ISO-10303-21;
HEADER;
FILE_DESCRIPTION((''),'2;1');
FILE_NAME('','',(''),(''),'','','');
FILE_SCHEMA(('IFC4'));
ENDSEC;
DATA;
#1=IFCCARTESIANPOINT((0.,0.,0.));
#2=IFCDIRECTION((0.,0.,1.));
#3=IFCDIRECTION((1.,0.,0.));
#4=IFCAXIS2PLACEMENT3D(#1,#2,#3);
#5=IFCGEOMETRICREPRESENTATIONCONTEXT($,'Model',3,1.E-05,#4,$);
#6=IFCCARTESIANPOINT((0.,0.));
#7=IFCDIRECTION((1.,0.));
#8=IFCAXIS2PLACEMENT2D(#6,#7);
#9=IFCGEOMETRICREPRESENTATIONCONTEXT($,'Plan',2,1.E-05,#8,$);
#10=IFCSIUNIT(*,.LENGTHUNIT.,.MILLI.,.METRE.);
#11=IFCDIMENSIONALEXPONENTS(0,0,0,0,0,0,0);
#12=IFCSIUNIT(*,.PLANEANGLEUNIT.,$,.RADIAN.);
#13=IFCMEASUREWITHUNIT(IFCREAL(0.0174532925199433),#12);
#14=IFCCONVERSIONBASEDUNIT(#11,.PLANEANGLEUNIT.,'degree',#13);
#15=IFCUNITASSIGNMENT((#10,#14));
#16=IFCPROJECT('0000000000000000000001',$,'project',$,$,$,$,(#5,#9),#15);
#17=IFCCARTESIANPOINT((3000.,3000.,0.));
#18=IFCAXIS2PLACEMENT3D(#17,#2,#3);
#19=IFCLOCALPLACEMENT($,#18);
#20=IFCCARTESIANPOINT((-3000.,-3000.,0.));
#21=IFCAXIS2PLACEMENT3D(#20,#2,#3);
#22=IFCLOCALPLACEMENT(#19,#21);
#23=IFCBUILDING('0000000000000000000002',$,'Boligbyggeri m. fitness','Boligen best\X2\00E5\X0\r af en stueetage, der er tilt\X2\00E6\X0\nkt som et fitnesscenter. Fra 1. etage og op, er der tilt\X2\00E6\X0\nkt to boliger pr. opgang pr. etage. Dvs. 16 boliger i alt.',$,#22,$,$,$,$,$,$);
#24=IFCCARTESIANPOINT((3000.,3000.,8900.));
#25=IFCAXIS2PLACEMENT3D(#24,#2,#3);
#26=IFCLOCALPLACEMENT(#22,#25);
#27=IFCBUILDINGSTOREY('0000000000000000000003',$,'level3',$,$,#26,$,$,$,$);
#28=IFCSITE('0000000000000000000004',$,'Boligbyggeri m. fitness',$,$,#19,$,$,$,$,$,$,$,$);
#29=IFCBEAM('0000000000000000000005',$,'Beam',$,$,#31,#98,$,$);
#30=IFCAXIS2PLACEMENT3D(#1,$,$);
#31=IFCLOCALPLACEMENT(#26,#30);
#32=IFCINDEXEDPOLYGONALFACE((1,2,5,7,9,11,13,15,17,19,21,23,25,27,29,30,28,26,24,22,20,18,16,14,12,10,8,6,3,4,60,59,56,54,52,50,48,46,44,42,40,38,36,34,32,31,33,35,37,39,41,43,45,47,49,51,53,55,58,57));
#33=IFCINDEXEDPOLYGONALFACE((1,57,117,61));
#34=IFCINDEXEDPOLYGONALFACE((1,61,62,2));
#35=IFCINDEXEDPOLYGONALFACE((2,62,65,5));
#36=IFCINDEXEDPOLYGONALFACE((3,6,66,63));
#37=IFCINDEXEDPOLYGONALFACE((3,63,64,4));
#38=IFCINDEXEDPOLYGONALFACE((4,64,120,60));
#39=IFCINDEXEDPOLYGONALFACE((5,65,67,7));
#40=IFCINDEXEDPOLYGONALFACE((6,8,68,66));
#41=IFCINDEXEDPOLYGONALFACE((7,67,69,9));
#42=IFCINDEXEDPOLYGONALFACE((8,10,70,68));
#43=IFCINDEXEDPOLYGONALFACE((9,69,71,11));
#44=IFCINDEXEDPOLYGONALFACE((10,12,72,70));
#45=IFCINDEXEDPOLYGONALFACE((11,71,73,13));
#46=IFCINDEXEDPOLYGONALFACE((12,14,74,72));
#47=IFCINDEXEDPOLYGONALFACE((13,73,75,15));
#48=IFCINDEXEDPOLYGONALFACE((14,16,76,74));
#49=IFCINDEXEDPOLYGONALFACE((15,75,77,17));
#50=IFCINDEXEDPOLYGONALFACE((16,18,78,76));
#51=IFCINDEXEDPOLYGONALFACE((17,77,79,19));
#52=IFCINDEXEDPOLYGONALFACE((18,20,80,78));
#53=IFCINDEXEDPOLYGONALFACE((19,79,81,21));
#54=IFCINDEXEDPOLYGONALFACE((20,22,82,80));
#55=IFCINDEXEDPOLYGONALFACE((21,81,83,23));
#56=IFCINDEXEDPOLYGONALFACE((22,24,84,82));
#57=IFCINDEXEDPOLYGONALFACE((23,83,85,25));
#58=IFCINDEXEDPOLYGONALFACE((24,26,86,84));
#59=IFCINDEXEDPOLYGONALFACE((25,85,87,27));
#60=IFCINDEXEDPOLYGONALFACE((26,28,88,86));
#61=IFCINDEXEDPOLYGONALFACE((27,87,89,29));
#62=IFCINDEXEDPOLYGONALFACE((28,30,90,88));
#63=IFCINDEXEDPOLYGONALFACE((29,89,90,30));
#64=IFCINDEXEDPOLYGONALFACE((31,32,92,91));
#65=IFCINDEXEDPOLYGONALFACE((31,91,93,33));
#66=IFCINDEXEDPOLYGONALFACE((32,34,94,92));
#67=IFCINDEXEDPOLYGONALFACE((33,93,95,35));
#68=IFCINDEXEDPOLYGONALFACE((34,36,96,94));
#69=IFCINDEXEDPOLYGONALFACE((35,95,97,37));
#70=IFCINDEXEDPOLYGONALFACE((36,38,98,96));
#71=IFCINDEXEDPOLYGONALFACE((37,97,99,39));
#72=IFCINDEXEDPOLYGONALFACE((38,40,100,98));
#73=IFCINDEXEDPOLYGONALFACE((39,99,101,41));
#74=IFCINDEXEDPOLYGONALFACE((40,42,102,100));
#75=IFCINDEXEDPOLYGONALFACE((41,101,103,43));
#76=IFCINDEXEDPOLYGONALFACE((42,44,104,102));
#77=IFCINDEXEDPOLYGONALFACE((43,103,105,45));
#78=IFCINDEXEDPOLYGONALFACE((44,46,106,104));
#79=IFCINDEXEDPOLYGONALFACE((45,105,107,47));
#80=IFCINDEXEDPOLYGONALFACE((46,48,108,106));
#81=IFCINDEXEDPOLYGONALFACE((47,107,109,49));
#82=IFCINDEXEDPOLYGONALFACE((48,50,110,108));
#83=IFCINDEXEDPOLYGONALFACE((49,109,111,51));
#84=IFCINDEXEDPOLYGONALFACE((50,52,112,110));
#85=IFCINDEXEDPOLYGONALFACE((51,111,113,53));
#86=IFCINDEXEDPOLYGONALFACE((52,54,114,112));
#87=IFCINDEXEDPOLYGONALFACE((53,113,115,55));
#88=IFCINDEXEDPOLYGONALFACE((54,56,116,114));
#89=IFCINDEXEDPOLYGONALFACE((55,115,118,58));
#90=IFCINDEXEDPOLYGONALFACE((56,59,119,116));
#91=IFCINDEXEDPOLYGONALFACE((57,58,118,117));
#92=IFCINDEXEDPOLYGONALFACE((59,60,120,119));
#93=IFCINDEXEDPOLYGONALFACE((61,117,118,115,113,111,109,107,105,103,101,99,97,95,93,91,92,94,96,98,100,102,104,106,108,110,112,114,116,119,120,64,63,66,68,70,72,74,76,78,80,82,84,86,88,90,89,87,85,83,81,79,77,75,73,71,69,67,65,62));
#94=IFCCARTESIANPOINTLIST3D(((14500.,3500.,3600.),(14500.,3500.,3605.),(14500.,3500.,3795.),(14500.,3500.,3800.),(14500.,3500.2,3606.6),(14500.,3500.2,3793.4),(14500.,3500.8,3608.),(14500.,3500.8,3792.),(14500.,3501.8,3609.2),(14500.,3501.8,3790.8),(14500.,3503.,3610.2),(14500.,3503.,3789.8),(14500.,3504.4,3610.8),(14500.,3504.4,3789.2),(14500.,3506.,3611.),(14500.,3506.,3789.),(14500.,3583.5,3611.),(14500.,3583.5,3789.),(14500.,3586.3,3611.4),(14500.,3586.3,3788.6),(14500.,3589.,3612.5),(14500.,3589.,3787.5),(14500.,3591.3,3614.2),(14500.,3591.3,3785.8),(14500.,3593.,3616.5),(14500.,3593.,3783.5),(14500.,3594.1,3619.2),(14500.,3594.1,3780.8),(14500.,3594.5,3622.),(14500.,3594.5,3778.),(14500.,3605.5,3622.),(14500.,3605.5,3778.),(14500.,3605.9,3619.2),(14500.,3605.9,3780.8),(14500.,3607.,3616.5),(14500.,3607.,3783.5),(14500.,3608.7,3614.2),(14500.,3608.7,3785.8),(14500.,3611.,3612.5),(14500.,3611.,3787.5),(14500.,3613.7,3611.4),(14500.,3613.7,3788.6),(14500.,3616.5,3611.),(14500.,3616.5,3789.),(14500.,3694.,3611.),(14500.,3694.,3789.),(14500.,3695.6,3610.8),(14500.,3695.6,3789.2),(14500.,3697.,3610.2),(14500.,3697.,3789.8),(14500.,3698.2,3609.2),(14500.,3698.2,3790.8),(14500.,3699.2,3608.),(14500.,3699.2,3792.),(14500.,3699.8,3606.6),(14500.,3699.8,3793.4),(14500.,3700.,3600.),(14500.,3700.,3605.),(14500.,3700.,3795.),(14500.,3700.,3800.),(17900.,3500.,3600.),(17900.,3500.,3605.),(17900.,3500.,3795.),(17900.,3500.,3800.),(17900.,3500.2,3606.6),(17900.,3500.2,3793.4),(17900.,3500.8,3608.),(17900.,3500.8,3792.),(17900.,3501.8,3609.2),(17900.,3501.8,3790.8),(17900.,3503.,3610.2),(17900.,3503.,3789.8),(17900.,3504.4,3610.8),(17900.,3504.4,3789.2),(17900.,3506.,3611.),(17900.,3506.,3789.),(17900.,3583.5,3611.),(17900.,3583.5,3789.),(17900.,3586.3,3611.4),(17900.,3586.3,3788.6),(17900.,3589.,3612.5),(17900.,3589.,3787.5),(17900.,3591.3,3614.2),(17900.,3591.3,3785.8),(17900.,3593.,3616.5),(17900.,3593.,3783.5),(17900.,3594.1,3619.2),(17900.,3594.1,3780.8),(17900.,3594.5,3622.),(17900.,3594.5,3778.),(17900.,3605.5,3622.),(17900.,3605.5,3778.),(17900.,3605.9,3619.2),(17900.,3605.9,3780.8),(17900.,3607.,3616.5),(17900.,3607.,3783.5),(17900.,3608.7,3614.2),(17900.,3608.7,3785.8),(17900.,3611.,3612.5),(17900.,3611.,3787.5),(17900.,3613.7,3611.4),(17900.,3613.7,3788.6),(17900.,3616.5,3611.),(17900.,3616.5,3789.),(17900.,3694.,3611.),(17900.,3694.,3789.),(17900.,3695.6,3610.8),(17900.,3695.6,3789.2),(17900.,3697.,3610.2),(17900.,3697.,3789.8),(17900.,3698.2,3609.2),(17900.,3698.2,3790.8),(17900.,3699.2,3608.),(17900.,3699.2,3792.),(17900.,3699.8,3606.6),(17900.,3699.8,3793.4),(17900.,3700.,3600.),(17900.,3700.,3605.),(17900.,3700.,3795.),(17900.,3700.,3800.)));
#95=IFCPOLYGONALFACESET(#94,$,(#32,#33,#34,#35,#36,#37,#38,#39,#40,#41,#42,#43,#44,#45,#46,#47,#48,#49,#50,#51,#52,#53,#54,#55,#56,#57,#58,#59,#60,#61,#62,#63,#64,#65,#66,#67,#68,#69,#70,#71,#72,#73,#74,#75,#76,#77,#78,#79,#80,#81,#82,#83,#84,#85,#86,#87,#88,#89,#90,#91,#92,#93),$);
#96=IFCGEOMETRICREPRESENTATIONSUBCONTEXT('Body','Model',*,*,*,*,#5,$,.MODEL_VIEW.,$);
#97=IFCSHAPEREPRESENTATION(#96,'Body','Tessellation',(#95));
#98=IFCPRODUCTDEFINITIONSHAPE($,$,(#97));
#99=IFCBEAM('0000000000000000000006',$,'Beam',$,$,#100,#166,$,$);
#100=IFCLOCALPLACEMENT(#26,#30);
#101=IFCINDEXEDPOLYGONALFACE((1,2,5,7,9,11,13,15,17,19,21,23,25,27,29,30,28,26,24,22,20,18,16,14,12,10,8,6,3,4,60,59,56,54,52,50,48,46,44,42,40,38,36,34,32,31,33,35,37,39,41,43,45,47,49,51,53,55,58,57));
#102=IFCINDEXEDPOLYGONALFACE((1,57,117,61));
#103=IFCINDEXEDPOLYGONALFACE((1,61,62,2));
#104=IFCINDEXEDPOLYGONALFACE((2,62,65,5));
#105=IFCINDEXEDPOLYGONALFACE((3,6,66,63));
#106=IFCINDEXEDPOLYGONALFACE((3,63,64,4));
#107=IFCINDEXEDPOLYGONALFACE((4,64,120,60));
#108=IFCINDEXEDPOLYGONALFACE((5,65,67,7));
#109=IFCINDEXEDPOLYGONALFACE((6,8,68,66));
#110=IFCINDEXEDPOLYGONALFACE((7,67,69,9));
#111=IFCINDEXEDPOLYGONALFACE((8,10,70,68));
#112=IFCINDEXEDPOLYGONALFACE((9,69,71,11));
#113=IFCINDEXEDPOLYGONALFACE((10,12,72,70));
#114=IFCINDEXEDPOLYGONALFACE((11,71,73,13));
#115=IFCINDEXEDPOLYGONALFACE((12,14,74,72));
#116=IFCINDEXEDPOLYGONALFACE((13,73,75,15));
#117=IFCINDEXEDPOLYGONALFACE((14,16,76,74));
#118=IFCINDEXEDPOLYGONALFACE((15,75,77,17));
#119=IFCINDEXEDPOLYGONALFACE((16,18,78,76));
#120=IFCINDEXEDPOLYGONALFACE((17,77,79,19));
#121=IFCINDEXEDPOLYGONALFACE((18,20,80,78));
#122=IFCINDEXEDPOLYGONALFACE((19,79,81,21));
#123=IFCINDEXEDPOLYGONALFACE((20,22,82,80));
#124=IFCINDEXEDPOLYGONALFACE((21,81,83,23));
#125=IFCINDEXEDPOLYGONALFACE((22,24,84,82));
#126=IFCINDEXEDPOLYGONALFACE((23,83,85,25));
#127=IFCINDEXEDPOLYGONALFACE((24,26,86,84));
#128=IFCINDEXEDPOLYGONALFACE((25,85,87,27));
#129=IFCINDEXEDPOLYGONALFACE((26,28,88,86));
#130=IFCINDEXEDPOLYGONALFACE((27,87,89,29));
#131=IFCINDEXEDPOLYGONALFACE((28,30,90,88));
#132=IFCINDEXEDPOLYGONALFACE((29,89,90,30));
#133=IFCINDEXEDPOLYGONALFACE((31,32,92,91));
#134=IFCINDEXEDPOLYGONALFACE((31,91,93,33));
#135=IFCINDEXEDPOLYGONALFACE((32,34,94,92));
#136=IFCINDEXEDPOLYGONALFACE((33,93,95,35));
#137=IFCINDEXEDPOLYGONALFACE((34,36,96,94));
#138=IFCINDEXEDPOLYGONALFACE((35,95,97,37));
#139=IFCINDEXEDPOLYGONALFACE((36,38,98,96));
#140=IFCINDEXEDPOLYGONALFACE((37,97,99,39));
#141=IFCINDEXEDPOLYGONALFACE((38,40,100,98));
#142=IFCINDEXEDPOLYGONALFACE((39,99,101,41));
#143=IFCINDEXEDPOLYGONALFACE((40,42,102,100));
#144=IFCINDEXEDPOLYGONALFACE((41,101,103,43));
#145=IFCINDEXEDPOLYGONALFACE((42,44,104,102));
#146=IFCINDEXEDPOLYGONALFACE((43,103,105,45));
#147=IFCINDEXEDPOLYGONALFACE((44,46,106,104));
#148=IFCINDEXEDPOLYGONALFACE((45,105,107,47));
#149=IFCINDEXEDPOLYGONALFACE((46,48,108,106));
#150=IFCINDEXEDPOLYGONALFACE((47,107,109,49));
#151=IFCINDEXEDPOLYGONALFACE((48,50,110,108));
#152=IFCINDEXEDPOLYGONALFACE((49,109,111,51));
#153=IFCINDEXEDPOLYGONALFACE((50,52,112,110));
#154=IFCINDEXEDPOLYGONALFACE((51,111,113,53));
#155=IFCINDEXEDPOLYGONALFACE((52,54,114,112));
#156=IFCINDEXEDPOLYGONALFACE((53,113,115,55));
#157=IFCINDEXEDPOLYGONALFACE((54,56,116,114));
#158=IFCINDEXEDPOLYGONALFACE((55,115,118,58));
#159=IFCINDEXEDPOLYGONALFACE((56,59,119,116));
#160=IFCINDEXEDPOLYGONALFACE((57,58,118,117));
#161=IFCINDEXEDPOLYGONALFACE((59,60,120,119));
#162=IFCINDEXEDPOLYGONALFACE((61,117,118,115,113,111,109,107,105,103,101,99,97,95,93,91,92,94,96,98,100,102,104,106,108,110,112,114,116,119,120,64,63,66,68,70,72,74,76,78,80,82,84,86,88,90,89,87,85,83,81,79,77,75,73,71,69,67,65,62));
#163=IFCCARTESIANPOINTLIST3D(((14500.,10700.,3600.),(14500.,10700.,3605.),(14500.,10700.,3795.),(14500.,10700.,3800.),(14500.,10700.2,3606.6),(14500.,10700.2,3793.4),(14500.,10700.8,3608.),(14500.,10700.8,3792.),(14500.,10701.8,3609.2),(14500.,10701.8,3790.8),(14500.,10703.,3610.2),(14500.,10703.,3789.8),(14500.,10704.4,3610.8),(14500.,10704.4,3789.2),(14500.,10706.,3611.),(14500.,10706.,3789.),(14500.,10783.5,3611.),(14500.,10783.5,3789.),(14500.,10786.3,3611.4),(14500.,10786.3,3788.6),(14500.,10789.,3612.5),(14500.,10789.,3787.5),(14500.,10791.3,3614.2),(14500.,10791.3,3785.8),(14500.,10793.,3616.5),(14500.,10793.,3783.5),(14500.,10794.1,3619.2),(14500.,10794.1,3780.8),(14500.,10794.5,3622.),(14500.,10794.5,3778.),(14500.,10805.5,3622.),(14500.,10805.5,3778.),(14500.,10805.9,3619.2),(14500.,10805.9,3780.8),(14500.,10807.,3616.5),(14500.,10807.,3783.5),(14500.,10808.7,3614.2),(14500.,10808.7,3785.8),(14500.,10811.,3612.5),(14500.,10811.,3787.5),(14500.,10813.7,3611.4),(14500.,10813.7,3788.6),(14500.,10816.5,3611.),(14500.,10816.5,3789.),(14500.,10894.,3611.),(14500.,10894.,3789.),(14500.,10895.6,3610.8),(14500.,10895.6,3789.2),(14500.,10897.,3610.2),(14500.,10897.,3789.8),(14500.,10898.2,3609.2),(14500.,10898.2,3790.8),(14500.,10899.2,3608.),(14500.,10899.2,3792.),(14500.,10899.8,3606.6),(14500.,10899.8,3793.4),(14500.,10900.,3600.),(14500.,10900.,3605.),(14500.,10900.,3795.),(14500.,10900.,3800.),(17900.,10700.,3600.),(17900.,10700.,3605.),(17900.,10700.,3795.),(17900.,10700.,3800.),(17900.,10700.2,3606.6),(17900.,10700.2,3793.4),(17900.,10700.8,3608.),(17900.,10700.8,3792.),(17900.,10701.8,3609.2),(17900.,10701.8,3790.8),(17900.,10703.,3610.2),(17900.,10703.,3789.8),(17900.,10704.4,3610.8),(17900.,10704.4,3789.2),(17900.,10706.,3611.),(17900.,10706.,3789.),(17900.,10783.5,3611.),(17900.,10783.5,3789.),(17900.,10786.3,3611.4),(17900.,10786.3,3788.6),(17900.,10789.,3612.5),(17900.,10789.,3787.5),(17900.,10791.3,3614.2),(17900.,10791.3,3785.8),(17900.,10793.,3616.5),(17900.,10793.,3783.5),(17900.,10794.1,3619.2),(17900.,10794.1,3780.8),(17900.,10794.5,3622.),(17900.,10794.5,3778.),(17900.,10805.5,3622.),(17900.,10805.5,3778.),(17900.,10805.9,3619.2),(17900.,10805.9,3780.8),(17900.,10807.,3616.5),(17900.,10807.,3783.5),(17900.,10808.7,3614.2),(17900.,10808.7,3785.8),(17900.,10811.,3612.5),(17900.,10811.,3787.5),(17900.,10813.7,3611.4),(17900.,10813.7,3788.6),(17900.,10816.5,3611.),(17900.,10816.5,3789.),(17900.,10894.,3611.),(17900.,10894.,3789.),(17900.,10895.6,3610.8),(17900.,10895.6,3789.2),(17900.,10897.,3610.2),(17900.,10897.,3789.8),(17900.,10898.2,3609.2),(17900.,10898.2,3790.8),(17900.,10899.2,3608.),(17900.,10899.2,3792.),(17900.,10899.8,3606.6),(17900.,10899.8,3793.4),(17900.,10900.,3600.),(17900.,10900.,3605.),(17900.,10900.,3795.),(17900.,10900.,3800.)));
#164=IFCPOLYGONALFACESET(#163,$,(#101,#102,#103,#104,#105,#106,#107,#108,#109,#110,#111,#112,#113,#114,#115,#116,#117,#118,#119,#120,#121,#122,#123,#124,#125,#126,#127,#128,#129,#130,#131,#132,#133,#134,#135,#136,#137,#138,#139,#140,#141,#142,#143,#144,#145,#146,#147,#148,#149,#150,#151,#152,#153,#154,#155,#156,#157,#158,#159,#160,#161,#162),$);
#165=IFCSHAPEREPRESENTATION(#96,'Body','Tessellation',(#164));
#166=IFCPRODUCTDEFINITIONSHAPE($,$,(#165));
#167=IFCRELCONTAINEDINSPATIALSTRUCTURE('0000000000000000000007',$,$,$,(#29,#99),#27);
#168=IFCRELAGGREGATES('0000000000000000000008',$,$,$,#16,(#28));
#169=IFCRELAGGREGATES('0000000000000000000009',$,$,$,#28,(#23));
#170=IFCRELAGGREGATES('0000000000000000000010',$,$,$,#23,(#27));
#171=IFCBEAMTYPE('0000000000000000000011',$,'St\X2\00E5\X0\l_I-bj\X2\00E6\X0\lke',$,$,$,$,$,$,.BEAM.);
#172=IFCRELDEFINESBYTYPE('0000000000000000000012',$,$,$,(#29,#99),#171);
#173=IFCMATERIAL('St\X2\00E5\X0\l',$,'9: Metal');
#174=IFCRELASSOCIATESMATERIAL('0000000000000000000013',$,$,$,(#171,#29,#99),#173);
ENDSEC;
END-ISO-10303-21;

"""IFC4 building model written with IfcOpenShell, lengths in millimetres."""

from ifc_helpers import new_model, entity, si_unit, converted_unit, frame, origin_with_axes, origin_2d_with_axis, place, context, subcontext, project, spatial, i_section, extrude, material, material_profile, profile_set, profile_usage, type_object, element, save


model = new_model("IFC4")

# Units and contexts
model_context = context("Model", 3, precision=1e-05, world=origin_with_axes())
plan_context = context("Plan", 2, precision=1e-05, world=origin_2d_with_axis())
body_context = subcontext(model_context, "Body", "Model", "MODEL_VIEW")
ifc_project = project(units=[si_unit("LENGTHUNIT", "METRE", prefix="MILLI"), converted_unit("PLANEANGLEUNIT", "degree", entity("IfcReal", 0.0174532925199433), si_unit("PLANEANGLEUNIT", "RADIAN"), dimensions=[0, 0, 0, 0, 0, 0, 0])], contexts=[model_context, plan_context])

# Site, building, storey
site_placement = place(None, frame((3000.0, 3000.0, 0.0), z_axis=(0.0, 0.0, 1.0), x_axis=(1.0, 0.0, 0.0)))
site = spatial("IfcSite", under=ifc_project, at=site_placement, Name="Boligbyggeri m. fitness")
building_placement = place(site_placement, frame((-3000.0, -3000.0, 0.0), z_axis=(0.0, 0.0, 1.0), x_axis=(1.0, 0.0, 0.0)))
building = spatial("IfcBuilding", under=site, at=building_placement, Name="Boligbyggeri m. fitness", Description="Boligen består af en stueetage, der er tiltænkt som et fitnesscenter. Fra 1. etage og op, er der tiltænkt to boliger pr. opgang pr. etage. Dvs. 16 boliger i alt.")
storey_placement = place(building_placement, frame((3000.0, 3000.0, 8900.0), z_axis=(0.0, 0.0, 1.0), x_axis=(1.0, 0.0, 0.0)))
storey = spatial("IfcBuildingStorey", under=building, at=storey_placement, Name="level3")

# Beams
ifc_material_1 = material(Name="Stål", Category="9: Metal")
ifc_material_profile_1 = material_profile(ifc_material_1, i_section(OverallWidth=200.0, OverallDepth=200.0, WebThickness=11.0, FlangeThickness=11.0, FilletRadius=11.0, FlangeEdgeRadius=6.0), Name="Stål", Category="9: Metal")
ifc_profile_set_1 = profile_set([ifc_material_profile_1], Name="NY_I-Profil")
beam_type = type_object("IfcBeamType", Name="Stål_I-bjælke", PredefinedType="BEAM", material=ifc_profile_set_1)
ifc_profile_usage_1 = profile_usage(ifc_profile_set_1, cardinal=7)
beam_1_placement = place(storey_placement, frame((14500.0, 3700.0, 3800.0), z_axis=(1.0, 0.0, 0.0), x_axis=(0.0, 1.0, 0.0)))
element("IfcBeam", 1, at=beam_1_placement, inside=storey, type_object=beam_type, material=ifc_profile_usage_1, Name="Beam", context=body_context, shape_type="SweptSolid", body=[
    extrude(i_section(OverallWidth=200.0, OverallDepth=200.0, WebThickness=11.0, FlangeThickness=11.0, FilletRadius=11.0, FlangeEdgeRadius=6.0), frame((-100.0, -100.0, 0.0), z_axis=(0.0, 0.0, 1.0), x_axis=(1.0, 0.0, 0.0)), (0.0, 0.0, 1.0), 3400.0),
])
ifc_profile_usage_2 = profile_usage(ifc_profile_set_1, cardinal=7)
beam_2_placement = place(storey_placement, frame((14500.0, 10900.0, 3800.0), z_axis=(1.0, 0.0, 0.0), x_axis=(0.0, 1.0, 0.0)))
element("IfcBeam", 2, at=beam_2_placement, inside=storey, type_object=beam_type, material=ifc_profile_usage_2, Name="Beam", context=body_context, shape_type="SweptSolid", body=[
    extrude(i_section(OverallWidth=200.0, OverallDepth=200.0, WebThickness=11.0, FlangeThickness=11.0, FilletRadius=11.0, FlangeEdgeRadius=6.0), frame((-100.0, -100.0, 0.0), z_axis=(0.0, 0.0, 1.0), x_axis=(1.0, 0.0, 0.0)), (0.0, 0.0, 1.0), 3400.0),
])

save(model, "model.ifc")
